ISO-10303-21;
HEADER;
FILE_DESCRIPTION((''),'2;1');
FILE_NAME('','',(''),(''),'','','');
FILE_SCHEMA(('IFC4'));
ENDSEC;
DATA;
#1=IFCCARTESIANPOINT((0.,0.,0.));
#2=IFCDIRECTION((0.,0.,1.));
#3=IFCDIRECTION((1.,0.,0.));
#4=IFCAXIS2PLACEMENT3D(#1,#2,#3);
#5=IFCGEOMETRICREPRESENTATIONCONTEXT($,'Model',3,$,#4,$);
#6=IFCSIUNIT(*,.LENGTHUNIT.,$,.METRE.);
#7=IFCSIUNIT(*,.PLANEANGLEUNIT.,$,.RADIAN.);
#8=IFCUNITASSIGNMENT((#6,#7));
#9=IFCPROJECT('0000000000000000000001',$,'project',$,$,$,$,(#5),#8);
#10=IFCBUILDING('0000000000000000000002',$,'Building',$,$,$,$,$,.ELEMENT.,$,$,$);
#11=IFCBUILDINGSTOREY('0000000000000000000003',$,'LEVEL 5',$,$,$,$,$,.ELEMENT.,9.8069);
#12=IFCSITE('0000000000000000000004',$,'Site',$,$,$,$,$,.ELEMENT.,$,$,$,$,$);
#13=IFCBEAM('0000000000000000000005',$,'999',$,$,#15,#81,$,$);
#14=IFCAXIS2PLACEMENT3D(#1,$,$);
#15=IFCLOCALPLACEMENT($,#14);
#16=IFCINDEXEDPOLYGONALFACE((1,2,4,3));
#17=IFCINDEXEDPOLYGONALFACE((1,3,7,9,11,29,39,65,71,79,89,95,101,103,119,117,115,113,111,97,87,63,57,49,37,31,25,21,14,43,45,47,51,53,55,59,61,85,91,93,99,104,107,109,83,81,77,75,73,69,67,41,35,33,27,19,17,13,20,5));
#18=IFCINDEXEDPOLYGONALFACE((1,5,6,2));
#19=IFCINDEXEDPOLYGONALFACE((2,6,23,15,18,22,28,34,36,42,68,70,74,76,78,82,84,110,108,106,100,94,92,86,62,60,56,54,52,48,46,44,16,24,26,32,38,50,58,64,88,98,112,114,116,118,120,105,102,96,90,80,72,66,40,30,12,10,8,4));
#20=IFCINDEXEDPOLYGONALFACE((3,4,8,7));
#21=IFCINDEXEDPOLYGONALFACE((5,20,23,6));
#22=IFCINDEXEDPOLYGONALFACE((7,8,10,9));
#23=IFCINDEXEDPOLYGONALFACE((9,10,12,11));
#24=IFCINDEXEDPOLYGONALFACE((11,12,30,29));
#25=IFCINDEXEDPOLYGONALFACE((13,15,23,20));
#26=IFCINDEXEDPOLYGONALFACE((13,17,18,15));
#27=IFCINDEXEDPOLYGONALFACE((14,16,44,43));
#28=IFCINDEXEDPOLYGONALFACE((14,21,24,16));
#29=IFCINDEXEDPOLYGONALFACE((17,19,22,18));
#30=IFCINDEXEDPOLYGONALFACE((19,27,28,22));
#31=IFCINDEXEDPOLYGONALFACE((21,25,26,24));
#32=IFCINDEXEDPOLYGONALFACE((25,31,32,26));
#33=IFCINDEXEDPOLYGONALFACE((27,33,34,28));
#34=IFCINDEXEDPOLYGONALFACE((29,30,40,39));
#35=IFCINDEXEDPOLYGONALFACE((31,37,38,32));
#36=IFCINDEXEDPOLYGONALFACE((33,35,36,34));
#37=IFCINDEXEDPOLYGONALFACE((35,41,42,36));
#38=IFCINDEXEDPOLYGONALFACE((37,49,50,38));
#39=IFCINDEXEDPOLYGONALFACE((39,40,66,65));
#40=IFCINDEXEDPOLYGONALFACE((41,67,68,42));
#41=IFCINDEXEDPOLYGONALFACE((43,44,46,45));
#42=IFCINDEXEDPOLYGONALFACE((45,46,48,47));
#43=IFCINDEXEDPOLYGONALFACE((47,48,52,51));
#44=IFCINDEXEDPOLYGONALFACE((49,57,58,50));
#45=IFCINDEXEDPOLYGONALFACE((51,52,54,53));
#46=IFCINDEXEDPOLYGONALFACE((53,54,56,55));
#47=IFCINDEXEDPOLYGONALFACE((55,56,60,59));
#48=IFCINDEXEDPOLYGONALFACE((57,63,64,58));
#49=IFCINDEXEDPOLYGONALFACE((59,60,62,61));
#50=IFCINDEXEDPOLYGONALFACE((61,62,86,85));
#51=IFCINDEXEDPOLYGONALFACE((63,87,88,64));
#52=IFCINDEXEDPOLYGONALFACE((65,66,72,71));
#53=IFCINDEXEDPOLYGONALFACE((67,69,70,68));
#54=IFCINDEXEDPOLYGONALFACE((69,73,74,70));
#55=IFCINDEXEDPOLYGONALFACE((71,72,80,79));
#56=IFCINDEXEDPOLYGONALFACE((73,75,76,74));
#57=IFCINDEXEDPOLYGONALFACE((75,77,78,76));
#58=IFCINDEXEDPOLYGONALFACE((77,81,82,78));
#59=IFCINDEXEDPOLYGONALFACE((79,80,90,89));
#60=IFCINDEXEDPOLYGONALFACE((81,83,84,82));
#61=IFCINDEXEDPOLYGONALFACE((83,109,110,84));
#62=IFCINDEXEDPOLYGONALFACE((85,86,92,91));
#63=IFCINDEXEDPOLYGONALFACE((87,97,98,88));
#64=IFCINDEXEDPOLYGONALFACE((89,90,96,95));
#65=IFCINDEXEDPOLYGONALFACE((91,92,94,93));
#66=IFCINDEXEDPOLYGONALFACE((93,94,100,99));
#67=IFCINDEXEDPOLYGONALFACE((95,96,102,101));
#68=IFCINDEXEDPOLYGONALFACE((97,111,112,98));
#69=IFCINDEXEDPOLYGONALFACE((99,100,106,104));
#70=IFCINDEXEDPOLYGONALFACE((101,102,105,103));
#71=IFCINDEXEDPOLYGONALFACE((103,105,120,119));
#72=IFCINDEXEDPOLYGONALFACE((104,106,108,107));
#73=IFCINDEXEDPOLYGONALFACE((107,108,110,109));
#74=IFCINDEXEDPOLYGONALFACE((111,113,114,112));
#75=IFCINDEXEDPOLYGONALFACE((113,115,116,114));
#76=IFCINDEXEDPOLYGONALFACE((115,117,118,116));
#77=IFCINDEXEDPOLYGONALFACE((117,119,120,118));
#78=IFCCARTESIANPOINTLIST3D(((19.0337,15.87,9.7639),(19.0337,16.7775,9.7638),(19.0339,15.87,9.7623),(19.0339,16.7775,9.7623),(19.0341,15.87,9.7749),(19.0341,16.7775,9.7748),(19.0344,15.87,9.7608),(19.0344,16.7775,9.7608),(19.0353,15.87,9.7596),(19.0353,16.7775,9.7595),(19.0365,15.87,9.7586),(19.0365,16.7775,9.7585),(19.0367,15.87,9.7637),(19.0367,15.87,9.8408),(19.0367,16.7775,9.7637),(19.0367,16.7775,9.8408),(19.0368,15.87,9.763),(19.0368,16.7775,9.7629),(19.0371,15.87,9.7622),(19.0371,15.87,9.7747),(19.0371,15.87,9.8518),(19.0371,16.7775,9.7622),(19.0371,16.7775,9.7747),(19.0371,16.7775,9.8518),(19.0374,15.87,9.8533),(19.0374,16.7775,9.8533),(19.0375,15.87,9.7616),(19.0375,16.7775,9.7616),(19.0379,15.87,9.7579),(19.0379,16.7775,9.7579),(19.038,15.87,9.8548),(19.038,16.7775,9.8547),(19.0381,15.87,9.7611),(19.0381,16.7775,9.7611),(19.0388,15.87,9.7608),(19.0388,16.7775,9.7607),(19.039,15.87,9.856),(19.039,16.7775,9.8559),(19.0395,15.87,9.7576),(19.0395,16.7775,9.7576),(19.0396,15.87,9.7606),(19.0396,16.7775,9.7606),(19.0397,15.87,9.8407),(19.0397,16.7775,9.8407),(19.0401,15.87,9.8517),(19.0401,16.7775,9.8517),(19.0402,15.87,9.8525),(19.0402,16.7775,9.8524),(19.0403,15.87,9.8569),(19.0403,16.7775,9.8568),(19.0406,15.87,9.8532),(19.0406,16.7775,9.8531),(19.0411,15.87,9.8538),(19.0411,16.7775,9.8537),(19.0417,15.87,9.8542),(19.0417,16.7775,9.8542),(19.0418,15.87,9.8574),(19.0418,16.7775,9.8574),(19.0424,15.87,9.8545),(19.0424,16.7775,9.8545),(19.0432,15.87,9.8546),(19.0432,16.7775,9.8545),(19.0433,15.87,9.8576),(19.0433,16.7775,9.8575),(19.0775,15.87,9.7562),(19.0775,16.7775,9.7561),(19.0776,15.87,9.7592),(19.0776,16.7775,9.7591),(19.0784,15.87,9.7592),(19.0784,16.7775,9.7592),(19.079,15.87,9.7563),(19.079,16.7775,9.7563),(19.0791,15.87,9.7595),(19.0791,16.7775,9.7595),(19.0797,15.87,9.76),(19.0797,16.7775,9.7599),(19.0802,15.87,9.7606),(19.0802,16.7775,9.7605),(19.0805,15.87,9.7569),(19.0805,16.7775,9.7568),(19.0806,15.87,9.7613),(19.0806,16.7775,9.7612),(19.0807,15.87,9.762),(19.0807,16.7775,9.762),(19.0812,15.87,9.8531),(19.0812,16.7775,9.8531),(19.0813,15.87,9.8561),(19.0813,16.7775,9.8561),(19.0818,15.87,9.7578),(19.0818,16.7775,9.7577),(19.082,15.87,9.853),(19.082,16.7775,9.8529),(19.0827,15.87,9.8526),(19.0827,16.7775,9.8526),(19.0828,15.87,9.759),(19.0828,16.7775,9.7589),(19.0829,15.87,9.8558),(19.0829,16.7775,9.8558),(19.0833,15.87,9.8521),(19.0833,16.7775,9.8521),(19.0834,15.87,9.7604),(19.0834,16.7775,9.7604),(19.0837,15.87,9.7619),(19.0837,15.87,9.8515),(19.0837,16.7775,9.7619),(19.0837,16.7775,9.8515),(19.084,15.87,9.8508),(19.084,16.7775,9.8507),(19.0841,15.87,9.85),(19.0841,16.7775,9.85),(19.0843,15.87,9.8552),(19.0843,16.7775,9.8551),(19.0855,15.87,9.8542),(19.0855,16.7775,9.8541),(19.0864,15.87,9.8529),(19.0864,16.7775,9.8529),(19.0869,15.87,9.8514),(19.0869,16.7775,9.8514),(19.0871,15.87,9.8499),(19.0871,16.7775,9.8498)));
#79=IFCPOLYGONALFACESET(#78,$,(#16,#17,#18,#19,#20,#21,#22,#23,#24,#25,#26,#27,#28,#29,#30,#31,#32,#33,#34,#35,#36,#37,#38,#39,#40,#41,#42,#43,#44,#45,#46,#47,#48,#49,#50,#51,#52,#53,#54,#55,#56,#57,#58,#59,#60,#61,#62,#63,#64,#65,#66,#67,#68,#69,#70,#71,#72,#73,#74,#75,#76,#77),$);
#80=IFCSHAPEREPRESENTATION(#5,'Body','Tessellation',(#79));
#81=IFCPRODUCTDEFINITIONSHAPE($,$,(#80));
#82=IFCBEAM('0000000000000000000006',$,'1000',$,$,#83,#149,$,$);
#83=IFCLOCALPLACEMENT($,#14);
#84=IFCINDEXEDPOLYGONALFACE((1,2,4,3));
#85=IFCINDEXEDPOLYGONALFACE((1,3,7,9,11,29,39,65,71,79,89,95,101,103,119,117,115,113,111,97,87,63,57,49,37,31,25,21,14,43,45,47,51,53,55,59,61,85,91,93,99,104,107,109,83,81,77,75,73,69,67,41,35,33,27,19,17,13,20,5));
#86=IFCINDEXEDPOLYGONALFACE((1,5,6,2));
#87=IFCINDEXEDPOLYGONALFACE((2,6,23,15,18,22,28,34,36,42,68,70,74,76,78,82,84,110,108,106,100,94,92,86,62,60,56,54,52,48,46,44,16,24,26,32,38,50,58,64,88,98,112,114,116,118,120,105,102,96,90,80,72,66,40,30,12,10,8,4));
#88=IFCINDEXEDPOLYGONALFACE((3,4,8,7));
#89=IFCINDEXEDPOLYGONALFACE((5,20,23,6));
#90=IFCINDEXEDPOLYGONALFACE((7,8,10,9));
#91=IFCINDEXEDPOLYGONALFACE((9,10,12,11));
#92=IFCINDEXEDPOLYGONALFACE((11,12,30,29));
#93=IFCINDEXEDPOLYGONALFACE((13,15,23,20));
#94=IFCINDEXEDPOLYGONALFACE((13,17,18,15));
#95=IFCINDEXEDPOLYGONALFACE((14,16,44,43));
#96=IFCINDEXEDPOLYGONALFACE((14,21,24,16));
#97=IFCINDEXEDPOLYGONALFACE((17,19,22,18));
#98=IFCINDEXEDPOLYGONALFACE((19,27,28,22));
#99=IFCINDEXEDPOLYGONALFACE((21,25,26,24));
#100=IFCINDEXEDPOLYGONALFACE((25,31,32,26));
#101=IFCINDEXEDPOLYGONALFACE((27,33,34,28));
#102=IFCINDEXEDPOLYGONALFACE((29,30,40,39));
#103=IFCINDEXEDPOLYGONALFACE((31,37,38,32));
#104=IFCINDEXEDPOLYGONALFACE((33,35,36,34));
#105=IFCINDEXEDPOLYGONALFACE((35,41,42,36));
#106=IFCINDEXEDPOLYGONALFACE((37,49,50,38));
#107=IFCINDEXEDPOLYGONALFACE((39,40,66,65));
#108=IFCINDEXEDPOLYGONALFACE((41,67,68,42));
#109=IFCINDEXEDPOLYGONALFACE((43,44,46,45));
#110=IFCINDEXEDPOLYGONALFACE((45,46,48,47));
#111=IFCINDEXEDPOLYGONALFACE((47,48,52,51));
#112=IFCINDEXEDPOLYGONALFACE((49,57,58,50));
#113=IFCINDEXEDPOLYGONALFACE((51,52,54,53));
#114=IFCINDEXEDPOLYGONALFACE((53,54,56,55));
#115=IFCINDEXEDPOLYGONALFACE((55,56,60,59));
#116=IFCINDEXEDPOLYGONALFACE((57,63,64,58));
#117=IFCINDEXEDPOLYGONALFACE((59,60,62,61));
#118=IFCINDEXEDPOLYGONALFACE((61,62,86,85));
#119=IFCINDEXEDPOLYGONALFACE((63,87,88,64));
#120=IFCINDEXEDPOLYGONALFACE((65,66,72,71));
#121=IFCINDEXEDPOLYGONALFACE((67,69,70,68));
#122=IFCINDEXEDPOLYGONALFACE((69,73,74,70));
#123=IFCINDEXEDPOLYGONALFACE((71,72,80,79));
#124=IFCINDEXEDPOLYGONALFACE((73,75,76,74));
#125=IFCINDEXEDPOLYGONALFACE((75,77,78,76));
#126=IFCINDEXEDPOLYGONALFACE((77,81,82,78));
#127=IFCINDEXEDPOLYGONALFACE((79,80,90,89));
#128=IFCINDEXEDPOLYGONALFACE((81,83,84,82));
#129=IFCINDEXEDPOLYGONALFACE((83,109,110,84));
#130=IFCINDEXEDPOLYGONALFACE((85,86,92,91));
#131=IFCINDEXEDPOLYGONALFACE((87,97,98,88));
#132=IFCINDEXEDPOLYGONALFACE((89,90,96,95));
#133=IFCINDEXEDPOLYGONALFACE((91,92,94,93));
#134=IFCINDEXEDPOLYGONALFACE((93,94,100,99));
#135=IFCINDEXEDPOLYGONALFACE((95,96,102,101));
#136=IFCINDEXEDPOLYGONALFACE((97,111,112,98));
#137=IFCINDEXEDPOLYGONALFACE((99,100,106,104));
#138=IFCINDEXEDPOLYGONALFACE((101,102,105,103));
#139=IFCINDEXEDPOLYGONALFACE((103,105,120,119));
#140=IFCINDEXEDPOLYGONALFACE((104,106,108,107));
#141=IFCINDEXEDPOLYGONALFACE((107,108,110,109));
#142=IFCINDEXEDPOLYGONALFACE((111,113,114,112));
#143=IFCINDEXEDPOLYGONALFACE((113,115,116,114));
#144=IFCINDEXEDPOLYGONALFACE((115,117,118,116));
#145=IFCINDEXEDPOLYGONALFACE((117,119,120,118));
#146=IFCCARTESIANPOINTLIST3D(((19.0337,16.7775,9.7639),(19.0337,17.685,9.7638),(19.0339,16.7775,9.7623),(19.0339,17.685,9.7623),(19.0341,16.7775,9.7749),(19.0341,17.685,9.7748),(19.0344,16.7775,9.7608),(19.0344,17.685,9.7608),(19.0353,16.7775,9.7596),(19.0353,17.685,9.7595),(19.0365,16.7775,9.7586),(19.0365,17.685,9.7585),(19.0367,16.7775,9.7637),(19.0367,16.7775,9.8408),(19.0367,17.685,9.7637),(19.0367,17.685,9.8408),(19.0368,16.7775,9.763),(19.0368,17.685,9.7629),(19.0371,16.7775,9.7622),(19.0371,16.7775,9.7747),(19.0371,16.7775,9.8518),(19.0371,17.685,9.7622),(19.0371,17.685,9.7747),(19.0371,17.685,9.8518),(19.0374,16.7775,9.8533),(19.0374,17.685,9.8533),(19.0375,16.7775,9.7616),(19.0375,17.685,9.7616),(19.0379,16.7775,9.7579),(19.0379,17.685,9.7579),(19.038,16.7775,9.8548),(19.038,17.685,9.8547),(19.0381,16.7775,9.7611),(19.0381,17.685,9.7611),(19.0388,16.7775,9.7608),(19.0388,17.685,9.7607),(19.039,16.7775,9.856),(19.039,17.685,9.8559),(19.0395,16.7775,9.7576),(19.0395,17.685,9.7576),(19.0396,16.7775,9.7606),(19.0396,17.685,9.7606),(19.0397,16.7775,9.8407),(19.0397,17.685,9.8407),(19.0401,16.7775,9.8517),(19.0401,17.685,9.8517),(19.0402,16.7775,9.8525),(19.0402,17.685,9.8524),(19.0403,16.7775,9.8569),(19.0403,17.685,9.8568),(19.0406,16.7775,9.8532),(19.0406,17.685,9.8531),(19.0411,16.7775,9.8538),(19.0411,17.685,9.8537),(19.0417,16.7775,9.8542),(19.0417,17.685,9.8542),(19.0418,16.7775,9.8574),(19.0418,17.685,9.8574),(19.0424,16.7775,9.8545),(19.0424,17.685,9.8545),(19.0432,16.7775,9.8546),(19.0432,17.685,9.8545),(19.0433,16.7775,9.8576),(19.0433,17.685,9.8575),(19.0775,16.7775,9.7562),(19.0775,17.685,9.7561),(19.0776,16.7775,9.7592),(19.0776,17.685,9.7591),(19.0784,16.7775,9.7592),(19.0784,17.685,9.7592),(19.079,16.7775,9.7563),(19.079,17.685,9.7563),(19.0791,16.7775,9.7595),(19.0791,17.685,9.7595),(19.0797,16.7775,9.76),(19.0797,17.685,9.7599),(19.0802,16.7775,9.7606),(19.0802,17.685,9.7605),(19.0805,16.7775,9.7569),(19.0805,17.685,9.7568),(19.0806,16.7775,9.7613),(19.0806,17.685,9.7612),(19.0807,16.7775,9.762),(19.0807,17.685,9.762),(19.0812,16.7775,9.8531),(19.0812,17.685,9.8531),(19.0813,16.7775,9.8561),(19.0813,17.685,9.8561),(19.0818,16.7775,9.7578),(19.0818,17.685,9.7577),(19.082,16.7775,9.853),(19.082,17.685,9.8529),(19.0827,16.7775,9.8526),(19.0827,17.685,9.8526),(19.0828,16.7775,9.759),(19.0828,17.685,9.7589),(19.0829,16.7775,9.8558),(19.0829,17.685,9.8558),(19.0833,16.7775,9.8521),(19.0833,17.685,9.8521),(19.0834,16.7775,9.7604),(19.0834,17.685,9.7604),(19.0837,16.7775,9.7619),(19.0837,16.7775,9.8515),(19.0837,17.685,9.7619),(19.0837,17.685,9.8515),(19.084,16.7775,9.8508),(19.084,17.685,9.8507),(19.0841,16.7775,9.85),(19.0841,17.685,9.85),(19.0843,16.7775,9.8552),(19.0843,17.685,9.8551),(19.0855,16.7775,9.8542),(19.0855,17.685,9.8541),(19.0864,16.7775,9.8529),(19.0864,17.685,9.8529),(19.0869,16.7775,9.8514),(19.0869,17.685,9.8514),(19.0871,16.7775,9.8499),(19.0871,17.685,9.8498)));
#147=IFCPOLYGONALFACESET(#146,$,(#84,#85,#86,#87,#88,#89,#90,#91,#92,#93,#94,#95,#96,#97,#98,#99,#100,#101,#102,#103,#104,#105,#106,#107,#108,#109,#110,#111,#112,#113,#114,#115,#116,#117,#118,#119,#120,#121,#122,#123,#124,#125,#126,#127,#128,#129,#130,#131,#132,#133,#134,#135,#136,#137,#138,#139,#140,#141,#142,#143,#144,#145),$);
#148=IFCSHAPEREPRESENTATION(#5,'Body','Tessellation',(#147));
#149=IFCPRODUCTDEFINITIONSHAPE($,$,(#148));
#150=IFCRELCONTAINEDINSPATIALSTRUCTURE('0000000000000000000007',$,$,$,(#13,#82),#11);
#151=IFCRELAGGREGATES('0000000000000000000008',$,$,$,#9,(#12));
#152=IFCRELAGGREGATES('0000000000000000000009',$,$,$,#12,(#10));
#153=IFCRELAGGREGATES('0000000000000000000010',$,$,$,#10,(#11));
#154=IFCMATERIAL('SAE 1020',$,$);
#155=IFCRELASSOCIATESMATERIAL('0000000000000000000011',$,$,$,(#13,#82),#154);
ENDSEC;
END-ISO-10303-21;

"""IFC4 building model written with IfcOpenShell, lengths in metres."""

from ifc_helpers import new_model, si_unit, frame, origin_with_axes, origin_2d_with_axis, place, context, project, spatial, c_section, extrude, material, material_profile, profile_set, profile_usage, element, save


model = new_model("IFC4")

# Units and contexts
model_context = context("Model", 3, world=origin_with_axes())
ifc_project = project(units=[si_unit("LENGTHUNIT", "METRE"), si_unit("PLANEANGLEUNIT", "RADIAN")], contexts=[model_context])

# Site, building, storey
site = spatial("IfcSite", under=ifc_project, Name="Site", CompositionType="ELEMENT")
building = spatial("IfcBuilding", under=site, Name="Building", CompositionType="ELEMENT")
storey = spatial("IfcBuildingStorey", under=building, Name="LEVEL 5", CompositionType="ELEMENT", Elevation=9.8069)

# Beams
ifc_material = material(Name="SAE 1020")
ifc_material_profile_1 = material_profile(ifc_material, c_section(Depth=0.1, Width=0.05, WallThickness=0.003, Girth=0.017, InternalFilletRadius=0.003, at=origin_2d_with_axis()))
ifc_profile_set_1 = profile_set([ifc_material_profile_1])
ifc_profile_usage_1 = profile_usage(ifc_profile_set_1, cardinal=10)
beam_1_placement = place(None, frame((19.0604, 15.87, 9.8069), z_axis=(0.0, 1.0, -0.00003), x_axis=(-0.999256, 0.000001, 0.038562)))
element("IfcBeam", 1, at=beam_1_placement, inside=storey, material=ifc_profile_usage_1, Name="999", context=model_context, shape_type="SweptSolid", body=[
    extrude(c_section(Depth=0.1, Width=0.05, WallThickness=0.003, Girth=0.017, InternalFilletRadius=0.003, at=origin_2d_with_axis()), origin_with_axes(), (0.0, 0.0, 1.0), 0.9075),
])
ifc_material_profile_2 = material_profile(ifc_material, c_section(Depth=0.1, Width=0.05, WallThickness=0.003, Girth=0.017, InternalFilletRadius=0.003, at=origin_2d_with_axis()))
ifc_profile_set_2 = profile_set([ifc_material_profile_2])
ifc_profile_usage_2 = profile_usage(ifc_profile_set_2, cardinal=10)
beam_2_placement = place(None, frame((19.0604, 16.7775, 9.8069), z_axis=(0.0, 1.0, -0.00003), x_axis=(-0.999256, 0.000001, 0.038562)))
element("IfcBeam", 2, at=beam_2_placement, inside=storey, material=ifc_profile_usage_2, Name="1000", context=model_context, shape_type="SweptSolid", body=[
    extrude(c_section(Depth=0.1, Width=0.05, WallThickness=0.003, Girth=0.017, InternalFilletRadius=0.003, at=origin_2d_with_axis()), origin_with_axes(), (0.0, 0.0, 1.0), 0.9075),
])

save(model, "model.ifc")
